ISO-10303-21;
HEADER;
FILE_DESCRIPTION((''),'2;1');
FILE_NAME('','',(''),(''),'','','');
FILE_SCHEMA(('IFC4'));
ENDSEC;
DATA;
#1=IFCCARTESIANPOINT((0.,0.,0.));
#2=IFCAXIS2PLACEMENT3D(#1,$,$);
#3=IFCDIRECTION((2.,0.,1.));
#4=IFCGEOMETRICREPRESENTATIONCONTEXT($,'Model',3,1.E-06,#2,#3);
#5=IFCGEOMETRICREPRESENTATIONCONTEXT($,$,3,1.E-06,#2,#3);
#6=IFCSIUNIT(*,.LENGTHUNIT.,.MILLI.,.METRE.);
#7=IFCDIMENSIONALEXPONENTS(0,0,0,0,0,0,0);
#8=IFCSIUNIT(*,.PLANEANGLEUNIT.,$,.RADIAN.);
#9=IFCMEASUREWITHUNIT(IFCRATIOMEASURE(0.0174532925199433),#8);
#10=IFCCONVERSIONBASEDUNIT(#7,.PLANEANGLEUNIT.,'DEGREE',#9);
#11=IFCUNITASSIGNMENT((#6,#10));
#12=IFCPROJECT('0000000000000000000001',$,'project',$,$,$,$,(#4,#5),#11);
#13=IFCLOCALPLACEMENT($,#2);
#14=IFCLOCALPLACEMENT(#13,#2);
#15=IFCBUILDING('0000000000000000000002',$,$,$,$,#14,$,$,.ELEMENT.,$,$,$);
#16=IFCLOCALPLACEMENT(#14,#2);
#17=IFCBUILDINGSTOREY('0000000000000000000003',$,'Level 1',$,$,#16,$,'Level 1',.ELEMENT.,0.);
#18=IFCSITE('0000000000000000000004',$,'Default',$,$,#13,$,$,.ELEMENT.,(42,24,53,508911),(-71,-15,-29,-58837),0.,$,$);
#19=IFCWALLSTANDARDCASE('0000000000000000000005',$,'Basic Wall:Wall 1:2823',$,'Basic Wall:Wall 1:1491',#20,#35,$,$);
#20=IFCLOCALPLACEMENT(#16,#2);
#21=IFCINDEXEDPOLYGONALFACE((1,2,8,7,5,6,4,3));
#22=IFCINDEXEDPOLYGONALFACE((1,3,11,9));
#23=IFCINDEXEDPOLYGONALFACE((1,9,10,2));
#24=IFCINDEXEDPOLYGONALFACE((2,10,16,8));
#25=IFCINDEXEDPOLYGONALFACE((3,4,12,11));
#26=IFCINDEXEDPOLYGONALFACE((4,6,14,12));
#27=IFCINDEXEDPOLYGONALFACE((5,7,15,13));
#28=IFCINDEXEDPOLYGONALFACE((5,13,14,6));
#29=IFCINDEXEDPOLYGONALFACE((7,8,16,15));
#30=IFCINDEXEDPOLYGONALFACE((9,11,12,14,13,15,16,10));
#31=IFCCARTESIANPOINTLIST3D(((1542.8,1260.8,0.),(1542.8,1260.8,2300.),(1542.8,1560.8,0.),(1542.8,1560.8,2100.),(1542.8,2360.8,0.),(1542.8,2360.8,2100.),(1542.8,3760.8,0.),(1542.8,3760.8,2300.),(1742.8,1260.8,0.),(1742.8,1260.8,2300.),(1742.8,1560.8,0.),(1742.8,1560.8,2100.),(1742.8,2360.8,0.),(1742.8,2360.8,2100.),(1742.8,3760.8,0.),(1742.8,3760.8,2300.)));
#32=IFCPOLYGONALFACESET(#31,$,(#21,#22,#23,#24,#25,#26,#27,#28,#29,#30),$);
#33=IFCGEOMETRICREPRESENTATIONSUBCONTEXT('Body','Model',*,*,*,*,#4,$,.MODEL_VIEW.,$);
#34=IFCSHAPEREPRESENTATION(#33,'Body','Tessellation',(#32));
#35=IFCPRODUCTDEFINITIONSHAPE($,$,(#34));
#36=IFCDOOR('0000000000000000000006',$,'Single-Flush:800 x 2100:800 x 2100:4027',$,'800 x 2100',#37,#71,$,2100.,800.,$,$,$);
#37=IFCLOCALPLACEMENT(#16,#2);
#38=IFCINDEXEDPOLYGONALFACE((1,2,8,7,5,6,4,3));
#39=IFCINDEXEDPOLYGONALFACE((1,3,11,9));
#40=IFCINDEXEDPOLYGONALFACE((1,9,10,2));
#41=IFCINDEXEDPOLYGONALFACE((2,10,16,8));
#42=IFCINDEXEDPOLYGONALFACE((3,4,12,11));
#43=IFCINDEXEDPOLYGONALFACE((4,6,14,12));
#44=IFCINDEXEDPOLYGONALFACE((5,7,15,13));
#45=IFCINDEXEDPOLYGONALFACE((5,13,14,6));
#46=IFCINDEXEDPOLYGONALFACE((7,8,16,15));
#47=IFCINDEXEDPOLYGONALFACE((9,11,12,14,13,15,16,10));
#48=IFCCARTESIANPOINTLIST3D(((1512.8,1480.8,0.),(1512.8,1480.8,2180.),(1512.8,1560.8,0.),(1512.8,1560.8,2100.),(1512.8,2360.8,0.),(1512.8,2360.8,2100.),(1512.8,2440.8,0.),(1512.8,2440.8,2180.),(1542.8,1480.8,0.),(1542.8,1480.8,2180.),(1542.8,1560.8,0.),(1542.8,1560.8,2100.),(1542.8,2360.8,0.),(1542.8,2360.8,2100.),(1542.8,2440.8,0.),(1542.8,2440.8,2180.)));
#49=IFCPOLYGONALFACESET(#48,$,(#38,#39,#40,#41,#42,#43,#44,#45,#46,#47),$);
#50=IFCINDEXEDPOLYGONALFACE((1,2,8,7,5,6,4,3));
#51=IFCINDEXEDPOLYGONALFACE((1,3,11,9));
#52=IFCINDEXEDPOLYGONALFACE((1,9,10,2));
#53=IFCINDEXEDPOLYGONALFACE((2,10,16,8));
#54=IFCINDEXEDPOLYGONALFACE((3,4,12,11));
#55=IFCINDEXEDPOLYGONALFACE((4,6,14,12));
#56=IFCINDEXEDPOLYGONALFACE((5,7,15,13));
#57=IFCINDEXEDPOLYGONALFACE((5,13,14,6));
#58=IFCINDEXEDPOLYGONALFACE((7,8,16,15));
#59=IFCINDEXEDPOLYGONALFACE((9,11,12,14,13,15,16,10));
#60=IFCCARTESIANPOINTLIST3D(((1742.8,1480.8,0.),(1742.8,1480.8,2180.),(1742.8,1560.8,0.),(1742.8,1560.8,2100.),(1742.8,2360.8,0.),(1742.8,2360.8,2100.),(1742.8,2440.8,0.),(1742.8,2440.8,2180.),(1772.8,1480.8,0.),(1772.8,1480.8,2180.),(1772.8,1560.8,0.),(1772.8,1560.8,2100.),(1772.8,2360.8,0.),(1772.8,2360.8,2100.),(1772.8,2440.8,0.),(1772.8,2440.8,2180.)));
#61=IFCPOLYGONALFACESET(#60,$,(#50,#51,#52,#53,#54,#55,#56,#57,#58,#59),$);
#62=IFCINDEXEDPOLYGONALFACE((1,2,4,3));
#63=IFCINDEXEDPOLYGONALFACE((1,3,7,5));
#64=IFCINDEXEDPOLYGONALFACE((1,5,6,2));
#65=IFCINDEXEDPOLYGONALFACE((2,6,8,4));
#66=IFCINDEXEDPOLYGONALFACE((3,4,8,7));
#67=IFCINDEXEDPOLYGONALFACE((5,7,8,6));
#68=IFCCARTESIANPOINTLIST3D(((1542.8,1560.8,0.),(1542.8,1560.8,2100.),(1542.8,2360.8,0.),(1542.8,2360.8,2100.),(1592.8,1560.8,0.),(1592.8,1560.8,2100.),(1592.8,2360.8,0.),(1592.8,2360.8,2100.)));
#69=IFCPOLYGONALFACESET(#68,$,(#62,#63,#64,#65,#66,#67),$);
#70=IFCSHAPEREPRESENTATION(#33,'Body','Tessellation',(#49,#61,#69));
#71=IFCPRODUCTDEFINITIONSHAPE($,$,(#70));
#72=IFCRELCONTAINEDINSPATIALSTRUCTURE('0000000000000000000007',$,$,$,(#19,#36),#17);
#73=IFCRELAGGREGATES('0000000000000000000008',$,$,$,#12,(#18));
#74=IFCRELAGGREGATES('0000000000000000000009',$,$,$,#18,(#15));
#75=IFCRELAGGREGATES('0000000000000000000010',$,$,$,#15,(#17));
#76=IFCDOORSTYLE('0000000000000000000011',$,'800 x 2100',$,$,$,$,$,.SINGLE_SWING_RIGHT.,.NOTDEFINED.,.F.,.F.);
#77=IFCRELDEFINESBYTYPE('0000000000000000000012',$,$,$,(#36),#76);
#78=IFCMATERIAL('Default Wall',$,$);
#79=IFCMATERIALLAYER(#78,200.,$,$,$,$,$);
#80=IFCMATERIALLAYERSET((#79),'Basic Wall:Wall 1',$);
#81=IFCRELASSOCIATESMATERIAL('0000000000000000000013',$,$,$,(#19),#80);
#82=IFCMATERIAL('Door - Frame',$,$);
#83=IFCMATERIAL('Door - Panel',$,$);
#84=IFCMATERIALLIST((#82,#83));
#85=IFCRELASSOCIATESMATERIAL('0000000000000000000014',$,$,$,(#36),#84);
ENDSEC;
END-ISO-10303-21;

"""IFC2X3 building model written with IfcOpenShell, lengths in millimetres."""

from ifc_helpers import new_model, entity, si_unit, converted_unit, direction, frame, frame_2d, origin, origin_2d_with_axis, place, context, subcontext, project, spatial, polyline, rectangle, outline, extrude, source, transform, mapped, material, material_list, layer, layer_set, layer_usage, type_object, type_shapes, element, fill, save


model = new_model("IFC2X3")

# Units and contexts
model_context = context("Model", 3, precision=1e-06, world=origin(), true_north=direction((2.0, 0.0, 1.0)))
context_of_model = context(None, 3, precision=1e-06, world=origin(), true_north=direction((2.0, 0.0, 1.0)))
body_context = subcontext(model_context, "Body", "Model", "MODEL_VIEW")
ifc_project = project(units=[si_unit("LENGTHUNIT", "METRE", prefix="MILLI"), converted_unit("PLANEANGLEUNIT", "DEGREE", entity("IfcRatioMeasure", 0.0174532925199433), si_unit("PLANEANGLEUNIT", "RADIAN"), dimensions=[0, 0, 0, 0, 0, 0, 0])], contexts=[model_context, context_of_model])

# Site, building, storey
site_placement = place(None, origin())
site = spatial("IfcSite", under=ifc_project, at=site_placement, Name="Default", CompositionType="ELEMENT", RefLatitude=(42, 24, 53, 508911), RefLongitude=(-71, -15, -29, -58837), RefElevation=0.0)
building_placement = place(site_placement, origin())
building = spatial("IfcBuilding", under=site, at=building_placement, CompositionType="ELEMENT")
storey_placement = place(building_placement, origin())
storey = spatial("IfcBuildingStorey", under=building, at=storey_placement, Name="Level 1", LongName="Level 1", CompositionType="ELEMENT", Elevation=0.0)

# Shared definitions
ifc_material_1 = material(Name="Default Wall")
ifc_layer = layer(ifc_material_1, 200.0)
ifc_layer_set = layer_set([ifc_layer], Name="Basic Wall:Wall 1")

# Wall, opening, door
ifc_layer_usage_1 = layer_usage(ifc_layer_set, "AXIS2", "NEGATIVE", 100.0)
wall_1_placement = place(storey_placement, frame((1642.8, 1260.8, 0.0), z_axis=(0.0, 0.0, 1.0), x_axis=(0.0, 1.0, 0.0)))
wall_1 = element("IfcWallStandardCase", 1, at=wall_1_placement, inside=storey, material=ifc_layer_usage_1, Name="Basic Wall:Wall 1:2823", ObjectType="Basic Wall:Wall 1:1491", context=body_context, shape_type="SweptSolid", body=[
    extrude(rectangle(XDim=2500.0, YDim=200.0, at=frame_2d((1250.0, 0.0), x_axis=(-1.0, 0.0))), origin(), (0.0, 0.0, 1.0), 2300.0),
])
opening_1_placement = place(wall_1_placement, frame((300.0, -100.0, 0.0)))
opening_1 = element("IfcOpeningElement", 2, at=opening_1_placement, cuts=wall_1, ObjectType="Opening", context=body_context, shape_type="SweptSolid", body=[
    extrude(rectangle(XDim=800.0, YDim=2100.0, at=frame_2d((1050.0, 400.0), x_axis=(0.0, 1.0))), frame((0.0, 0.0, 0.0), z_axis=(0.0, 1.0, 0.0), x_axis=(0.0, 0.0, 1.0)), (0.0, 0.0, 1.0), 200.0),
])
ifc_material_2 = material(Name="Door - Frame")
ifc_material_3 = material(Name="Door - Panel")
ifc_material_list_1 = material_list([ifc_material_2, ifc_material_3])
door_style = type_object("IfcDoorStyle", Name="800 x 2100", ConstructionType="NOTDEFINED", OperationType="SINGLE_SWING_RIGHT", ParameterTakesPrecedence=False, Sizeable=False)
shared_shape_1 = source(origin(), body_context, "Body", "SweptSolid", [
    extrude(outline(polyline([(-480.0, -1110.0), (480.0, -1110.0), (480.0, 1070.0), (400.0, 1070.0), (400.0, -1030.0), (-400.0, -1030.0), (-400.0, 1070.0), (-480.0, 1070.0), (-480.0, -1110.0)])), frame((400.0, 200.0, 1070.0), z_axis=(0.0, 1.0, 0.0), x_axis=(1.0, 0.0, 0.0)), (0.0, 0.0, 1.0), 30.0),
    extrude(outline(polyline([(-1110.0, -480.0), (1070.0, -480.0), (1070.0, -400.0), (-1030.0, -400.0), (-1030.0, 400.0), (1070.0, 400.0), (1070.0, 480.0), (-1110.0, 480.0), (-1110.0, -480.0)])), frame((400.0, -30.0, 1070.0), z_axis=(0.0, 1.0, 0.0), x_axis=(0.0, 0.0, -1.0)), (0.0, 0.0, 1.0), 30.0),
    extrude(rectangle(XDim=50.0, YDim=800.0, at=origin_2d_with_axis()), frame((400.0, 175.0, 0.0), z_axis=(0.0, 0.0, 1.0), x_axis=(0.0, 1.0, 0.0)), (0.0, 0.0, 1.0), 2100.0),
])
type_shapes(door_style, [shared_shape_1])
door_placement = place(opening_1_placement, origin())
door = element("IfcDoor", 3, at=door_placement, inside=storey, type_object=door_style, material=ifc_material_list_1, Name="Single-Flush:800 x 2100:800 x 2100:4027", ObjectType="800 x 2100", OverallHeight=2100.0, OverallWidth=800.0, context=body_context, shape_type="MappedRepresentation", body=[
    mapped(shared_shape_1, transform((0.0, 0.0, 0.0), scale=1.0)),
])
fill(opening_1, door)

save(model, "model.ifc")
